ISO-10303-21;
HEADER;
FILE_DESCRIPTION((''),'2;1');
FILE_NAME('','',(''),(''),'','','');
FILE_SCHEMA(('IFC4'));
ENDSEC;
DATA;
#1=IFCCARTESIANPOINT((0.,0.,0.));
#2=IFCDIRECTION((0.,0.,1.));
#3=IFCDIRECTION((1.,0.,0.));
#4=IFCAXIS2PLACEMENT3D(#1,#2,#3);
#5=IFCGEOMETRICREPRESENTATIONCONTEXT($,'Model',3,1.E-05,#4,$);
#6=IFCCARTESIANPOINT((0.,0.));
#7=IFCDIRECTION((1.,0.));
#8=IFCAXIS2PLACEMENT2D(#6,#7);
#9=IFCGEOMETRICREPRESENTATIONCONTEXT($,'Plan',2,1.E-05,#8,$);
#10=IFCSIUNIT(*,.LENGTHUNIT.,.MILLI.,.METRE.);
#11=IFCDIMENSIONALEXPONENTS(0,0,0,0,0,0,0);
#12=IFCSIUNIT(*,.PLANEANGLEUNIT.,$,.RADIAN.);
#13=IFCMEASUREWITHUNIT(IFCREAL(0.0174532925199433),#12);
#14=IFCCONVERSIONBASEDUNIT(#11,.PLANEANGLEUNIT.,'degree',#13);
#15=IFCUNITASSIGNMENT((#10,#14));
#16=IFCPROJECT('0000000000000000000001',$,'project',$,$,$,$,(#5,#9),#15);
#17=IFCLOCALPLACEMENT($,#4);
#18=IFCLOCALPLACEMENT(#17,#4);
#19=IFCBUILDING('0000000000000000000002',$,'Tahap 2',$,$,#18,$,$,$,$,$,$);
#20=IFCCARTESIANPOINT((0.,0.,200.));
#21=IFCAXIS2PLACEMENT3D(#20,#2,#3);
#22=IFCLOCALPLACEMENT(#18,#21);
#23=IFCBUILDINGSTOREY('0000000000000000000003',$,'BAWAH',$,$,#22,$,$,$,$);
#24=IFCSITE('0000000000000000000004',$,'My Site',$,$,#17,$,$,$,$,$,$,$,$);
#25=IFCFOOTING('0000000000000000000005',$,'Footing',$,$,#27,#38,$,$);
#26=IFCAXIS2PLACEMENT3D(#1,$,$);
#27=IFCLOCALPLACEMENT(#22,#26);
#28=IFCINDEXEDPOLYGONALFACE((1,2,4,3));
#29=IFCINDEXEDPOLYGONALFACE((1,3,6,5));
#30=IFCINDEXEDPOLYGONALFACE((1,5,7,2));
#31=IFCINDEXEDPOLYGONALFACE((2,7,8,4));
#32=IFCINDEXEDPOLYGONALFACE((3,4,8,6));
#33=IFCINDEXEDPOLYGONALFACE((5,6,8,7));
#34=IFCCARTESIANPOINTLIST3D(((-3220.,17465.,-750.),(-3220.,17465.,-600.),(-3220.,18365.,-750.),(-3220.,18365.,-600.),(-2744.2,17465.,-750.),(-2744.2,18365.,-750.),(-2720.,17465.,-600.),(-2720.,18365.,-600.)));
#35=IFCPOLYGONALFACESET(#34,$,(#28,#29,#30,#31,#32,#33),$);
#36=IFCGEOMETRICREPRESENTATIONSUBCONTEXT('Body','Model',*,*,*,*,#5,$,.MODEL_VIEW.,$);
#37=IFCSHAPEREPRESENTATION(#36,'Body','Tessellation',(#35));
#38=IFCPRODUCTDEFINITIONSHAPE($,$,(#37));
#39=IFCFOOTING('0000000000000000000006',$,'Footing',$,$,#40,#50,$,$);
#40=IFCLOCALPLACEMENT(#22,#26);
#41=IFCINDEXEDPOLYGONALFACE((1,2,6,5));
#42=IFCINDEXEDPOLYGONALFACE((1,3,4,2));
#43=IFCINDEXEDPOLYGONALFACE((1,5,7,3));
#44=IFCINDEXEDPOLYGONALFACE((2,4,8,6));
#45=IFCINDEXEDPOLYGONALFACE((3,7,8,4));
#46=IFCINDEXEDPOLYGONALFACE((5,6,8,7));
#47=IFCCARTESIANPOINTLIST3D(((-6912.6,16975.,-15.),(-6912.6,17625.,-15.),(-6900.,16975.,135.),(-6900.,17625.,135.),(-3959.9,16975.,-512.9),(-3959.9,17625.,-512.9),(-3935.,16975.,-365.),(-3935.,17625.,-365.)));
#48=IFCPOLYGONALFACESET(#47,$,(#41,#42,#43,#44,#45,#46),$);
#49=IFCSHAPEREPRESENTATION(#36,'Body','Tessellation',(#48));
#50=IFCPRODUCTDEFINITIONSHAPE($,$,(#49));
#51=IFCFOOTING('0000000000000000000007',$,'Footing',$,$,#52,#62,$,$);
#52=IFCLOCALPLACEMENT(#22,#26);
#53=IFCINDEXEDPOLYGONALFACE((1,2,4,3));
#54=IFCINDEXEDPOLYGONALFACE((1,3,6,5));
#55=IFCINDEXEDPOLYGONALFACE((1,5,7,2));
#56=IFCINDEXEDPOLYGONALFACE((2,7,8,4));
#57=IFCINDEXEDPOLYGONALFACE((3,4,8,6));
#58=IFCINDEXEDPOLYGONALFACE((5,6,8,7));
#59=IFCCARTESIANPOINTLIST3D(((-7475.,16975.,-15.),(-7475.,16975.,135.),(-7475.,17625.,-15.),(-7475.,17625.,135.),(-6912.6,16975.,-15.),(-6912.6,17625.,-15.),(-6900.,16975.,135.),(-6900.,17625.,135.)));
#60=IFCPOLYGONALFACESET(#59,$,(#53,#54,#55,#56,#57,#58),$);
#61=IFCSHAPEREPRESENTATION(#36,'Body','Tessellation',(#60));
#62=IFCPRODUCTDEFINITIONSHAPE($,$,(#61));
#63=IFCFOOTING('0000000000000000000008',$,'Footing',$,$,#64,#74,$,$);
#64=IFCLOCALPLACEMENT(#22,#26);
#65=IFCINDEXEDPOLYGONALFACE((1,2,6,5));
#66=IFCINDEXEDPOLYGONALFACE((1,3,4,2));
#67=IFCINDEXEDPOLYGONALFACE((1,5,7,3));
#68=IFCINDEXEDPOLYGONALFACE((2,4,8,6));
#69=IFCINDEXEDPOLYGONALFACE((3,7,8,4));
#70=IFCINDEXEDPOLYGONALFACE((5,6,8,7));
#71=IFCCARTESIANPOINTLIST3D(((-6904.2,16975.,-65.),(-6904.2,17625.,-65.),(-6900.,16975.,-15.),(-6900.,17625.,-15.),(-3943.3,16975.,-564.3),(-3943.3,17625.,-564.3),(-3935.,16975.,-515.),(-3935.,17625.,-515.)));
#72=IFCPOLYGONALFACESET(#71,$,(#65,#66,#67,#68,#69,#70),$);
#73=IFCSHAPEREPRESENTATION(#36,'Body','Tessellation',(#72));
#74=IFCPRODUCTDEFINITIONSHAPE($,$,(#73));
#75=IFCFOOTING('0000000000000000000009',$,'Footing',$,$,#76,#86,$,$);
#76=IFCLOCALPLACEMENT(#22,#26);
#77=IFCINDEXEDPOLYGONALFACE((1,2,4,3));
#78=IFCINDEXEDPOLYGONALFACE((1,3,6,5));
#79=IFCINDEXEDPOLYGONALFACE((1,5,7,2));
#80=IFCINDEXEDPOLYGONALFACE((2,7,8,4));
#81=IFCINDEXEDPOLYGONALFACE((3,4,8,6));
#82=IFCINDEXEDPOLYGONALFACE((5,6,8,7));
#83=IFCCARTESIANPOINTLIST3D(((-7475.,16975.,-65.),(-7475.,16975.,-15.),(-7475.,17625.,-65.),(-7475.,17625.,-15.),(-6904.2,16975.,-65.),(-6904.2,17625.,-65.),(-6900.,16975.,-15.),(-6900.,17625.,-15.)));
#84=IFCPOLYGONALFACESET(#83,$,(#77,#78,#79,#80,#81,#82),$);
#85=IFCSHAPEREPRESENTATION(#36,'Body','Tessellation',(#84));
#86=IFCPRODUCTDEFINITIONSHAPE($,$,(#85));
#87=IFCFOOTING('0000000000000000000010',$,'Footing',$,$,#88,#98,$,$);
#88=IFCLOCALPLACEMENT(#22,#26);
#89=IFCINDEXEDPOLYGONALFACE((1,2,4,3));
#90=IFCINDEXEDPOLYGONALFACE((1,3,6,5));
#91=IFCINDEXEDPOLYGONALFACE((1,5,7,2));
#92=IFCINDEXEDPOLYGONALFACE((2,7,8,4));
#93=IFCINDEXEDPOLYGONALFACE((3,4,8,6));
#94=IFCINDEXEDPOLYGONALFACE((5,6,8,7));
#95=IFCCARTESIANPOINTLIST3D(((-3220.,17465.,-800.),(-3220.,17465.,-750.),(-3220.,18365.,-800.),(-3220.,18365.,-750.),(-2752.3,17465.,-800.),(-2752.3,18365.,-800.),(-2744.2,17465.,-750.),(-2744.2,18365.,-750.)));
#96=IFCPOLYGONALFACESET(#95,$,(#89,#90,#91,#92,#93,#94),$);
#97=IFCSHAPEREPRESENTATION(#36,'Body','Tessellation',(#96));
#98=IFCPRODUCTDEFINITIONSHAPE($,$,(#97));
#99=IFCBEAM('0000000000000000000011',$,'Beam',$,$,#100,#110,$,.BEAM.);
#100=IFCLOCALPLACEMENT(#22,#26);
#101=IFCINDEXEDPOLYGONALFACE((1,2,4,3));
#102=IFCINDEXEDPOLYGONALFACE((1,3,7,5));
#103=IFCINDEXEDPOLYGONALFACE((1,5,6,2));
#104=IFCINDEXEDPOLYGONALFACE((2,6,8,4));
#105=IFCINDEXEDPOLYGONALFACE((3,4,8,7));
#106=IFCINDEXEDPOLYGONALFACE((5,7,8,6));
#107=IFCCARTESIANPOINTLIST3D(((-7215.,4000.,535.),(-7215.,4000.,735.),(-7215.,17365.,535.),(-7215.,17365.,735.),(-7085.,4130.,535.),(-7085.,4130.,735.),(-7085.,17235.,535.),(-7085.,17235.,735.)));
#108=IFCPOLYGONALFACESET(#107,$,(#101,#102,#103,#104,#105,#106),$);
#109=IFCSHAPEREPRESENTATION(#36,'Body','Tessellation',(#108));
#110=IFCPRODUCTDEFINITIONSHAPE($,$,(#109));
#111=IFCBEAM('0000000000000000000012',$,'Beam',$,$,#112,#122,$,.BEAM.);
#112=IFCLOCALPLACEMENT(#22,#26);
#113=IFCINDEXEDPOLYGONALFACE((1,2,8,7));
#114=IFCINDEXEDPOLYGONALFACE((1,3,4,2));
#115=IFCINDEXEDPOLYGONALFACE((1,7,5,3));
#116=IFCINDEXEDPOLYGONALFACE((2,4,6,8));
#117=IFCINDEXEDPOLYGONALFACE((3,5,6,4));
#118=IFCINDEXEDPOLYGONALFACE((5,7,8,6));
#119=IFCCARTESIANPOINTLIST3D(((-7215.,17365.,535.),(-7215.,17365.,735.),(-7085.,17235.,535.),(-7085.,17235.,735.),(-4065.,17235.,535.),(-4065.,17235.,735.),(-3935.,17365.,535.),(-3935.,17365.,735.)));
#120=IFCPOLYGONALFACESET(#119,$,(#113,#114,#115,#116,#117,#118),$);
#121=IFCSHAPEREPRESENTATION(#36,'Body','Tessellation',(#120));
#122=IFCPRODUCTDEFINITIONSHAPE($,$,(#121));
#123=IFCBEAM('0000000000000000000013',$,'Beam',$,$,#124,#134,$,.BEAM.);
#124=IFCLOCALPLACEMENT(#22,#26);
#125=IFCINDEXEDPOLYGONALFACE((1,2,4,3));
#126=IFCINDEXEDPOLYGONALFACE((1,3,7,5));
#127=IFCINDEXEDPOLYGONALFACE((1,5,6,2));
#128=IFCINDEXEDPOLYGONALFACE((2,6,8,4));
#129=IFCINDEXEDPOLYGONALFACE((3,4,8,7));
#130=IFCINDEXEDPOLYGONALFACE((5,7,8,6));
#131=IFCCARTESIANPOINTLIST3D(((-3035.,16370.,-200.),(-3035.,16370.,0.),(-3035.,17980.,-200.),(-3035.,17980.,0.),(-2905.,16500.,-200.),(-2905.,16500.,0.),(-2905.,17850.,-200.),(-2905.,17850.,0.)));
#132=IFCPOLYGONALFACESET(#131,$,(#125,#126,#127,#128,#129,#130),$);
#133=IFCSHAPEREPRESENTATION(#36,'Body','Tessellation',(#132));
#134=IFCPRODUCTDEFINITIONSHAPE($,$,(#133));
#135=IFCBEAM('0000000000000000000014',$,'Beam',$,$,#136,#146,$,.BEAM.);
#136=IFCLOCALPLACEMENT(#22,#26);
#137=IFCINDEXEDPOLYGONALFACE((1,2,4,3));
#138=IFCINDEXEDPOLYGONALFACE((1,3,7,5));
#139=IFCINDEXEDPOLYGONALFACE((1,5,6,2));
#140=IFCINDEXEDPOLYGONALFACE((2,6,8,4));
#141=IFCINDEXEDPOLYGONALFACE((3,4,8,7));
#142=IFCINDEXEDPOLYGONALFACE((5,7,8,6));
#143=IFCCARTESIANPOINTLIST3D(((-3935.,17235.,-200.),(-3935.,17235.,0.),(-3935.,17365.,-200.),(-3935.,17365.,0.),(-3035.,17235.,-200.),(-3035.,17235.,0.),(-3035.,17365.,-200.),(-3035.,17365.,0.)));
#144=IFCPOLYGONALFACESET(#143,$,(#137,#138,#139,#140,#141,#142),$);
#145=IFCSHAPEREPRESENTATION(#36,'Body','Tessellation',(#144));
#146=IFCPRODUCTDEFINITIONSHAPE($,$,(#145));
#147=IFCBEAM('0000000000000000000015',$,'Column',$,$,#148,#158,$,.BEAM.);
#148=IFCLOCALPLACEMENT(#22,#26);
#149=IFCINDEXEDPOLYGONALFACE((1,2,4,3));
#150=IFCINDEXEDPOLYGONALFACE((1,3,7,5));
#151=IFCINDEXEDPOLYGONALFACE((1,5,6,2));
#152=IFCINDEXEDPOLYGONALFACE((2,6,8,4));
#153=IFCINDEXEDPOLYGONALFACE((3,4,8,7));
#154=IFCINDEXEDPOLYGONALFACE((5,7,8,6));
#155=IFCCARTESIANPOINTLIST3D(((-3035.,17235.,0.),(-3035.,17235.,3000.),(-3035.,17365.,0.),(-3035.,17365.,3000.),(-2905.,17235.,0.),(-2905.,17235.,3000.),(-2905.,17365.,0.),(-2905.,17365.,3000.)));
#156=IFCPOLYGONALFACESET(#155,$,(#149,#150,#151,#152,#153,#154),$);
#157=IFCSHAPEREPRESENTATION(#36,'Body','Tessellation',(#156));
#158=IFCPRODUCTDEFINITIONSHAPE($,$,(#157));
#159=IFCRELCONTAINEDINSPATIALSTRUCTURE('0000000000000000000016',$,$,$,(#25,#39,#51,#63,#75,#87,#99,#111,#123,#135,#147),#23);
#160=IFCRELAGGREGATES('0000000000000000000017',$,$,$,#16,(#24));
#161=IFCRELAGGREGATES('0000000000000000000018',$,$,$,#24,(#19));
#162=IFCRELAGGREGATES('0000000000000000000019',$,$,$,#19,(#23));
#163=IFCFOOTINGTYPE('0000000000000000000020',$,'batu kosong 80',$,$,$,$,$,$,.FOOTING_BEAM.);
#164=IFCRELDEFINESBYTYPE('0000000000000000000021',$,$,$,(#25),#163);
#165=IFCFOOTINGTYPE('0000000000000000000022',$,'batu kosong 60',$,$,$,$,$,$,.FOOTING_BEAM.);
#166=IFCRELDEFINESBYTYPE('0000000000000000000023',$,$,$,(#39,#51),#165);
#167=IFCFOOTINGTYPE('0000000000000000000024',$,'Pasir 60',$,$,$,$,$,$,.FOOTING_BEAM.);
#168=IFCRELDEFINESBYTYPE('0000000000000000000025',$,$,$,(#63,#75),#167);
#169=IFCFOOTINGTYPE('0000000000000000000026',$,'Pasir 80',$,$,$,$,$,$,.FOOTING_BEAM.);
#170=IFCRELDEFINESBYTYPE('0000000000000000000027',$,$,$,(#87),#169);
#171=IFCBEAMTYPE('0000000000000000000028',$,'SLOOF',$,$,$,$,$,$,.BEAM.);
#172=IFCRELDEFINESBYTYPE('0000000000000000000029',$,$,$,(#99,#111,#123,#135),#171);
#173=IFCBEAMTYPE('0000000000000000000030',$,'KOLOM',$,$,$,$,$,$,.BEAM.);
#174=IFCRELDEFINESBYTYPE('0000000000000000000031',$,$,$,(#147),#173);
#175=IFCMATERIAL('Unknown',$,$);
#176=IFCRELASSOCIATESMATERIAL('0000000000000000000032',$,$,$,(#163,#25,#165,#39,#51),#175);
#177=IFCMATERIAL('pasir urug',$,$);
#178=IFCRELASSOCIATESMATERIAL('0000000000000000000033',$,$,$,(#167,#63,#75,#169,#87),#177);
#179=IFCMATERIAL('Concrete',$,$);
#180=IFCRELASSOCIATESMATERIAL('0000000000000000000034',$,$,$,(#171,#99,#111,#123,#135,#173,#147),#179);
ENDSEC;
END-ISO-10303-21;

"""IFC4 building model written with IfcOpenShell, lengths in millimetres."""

from ifc_helpers import new_model, entity, si_unit, converted_unit, frame, origin_with_axes, origin_2d_with_axis, place, context, subcontext, project, spatial, indexed_curve, rectangle, outline, extrude, clip, halfspace, material, material_profile, profile_set, profile_usage, type_object, element, save


model = new_model("IFC4")

# Units and contexts
model_context = context("Model", 3, precision=1e-05, world=origin_with_axes())
plan_context = context("Plan", 2, precision=1e-05, world=origin_2d_with_axis())
body_context = subcontext(model_context, "Body", "Model", "MODEL_VIEW")
ifc_project = project(units=[si_unit("LENGTHUNIT", "METRE", prefix="MILLI"), converted_unit("PLANEANGLEUNIT", "degree", entity("IfcReal", 0.0174532925199433), si_unit("PLANEANGLEUNIT", "RADIAN"), dimensions=[0, 0, 0, 0, 0, 0, 0])], contexts=[model_context, plan_context])

# Site, building, storey
site_placement = place(None, origin_with_axes())
site = spatial("IfcSite", under=ifc_project, at=site_placement, Name="My Site")
building_placement = place(site_placement, origin_with_axes())
building = spatial("IfcBuilding", under=site, at=building_placement, Name="Tahap 2")
storey_placement = place(building_placement, frame((0.0, 0.0, 200.0), z_axis=(0.0, 0.0, 1.0), x_axis=(1.0, 0.0, 0.0)))
storey = spatial("IfcBuildingStorey", under=building, at=storey_placement, Name="BAWAH")

# Footings
ifc_material_1 = material(Name="Unknown")
ifc_material_profile_1 = material_profile(ifc_material_1, rectangle(XDim=900.0, YDim=150.0, kind="CURVE"))
ifc_profile_set_1 = profile_set([ifc_material_profile_1])
ifc_profile_usage_1 = profile_usage(ifc_profile_set_1, cardinal=8)
footing_type_1 = type_object("IfcFootingType", Name="batu kosong 80", PredefinedType="FOOTING_BEAM", material=ifc_profile_set_1)
footing_1_placement = place(storey_placement, frame((-1820.0, 17915.0, -600.0), z_axis=(-1.0, 0.0, 0.0), x_axis=(0.0, -1.0, 0.0)))
element("IfcFooting", 1, at=footing_1_placement, inside=storey, type_object=footing_type_1, material=ifc_profile_usage_1, Name="Footing", context=body_context, shape_type="Clipping", body=[
    clip(extrude(rectangle(XDim=900.0, YDim=150.0, kind="CURVE"), frame((0.0, -75.0, 0.0), z_axis=(0.0, 0.0, 1.0), x_axis=(1.0, 0.0, 0.0)), (0.0, 0.0, 1.0), 1400.0), halfspace(frame((17915.0, 0.0, 900.0), z_axis=(0.0, -0.159352, -0.987222), x_axis=(-1.0, 0.0, 0.0)), False)),
])
ifc_material_profile_2 = material_profile(ifc_material_1, rectangle(XDim=650.0, YDim=150.0, kind="CURVE"))
ifc_profile_set_2 = profile_set([ifc_material_profile_2])
ifc_profile_usage_2 = profile_usage(ifc_profile_set_2, cardinal=8)
footing_type_2 = type_object("IfcFootingType", Name="batu kosong 60", PredefinedType="FOOTING_BEAM", material=ifc_profile_set_2)
footing_2_placement = place(storey_placement, frame((-3935.0, 17300.0, -365.0), z_axis=(-0.986078, 0.0, 0.166286), x_axis=(0.0, -1.0, 0.0)))
element("IfcFooting", 2, at=footing_2_placement, inside=storey, type_object=footing_type_2, material=ifc_profile_usage_2, Name="Footing", context=body_context, shape_type="Clipping", body=[
    clip(extrude(rectangle(XDim=650.0, YDim=150.0, kind="CURVE"), frame((0.0, -75.0, 0.0), z_axis=(0.0, 0.0, 1.0), x_axis=(1.0, 0.0, 0.0)), (0.0, 0.0, 1.0), 3656.9), halfspace(frame((17300.0, 0.0, 3006.9), z_axis=(-0.000001, -0.08343, 0.996514), x_axis=(-1.0, 0.000008, 0.0)), False)),
])
ifc_profile_usage_3 = profile_usage(ifc_profile_set_2, cardinal=8)
footing_3_placement = place(storey_placement, frame((-6250.0, 17300.0, 135.0), z_axis=(-1.0, 0.0, 0.0), x_axis=(0.0, -1.0, 0.0)))
element("IfcFooting", 3, at=footing_3_placement, inside=storey, type_object=footing_type_2, material=ifc_profile_usage_3, Name="Footing", context=body_context, shape_type="Clipping", body=[
    clip(extrude(rectangle(XDim=650.0, YDim=150.0, kind="CURVE"), frame((0.0, -75.0, 0.0), z_axis=(0.0, 0.0, 1.0), x_axis=(1.0, 0.0, 0.0)), (0.0, 0.0, 1.0), 1225.0), halfspace(frame((17300.0, 0.0, 650.0), z_axis=(0.000001, -0.083437, -0.996513), x_axis=(-1.0, -0.000011, 0.0)), False)),
])
ifc_material_2 = material(Name="pasir urug")
ifc_material_profile_3 = material_profile(ifc_material_2, rectangle(XDim=650.0, YDim=50.0, kind="CURVE"))
ifc_profile_set_3 = profile_set([ifc_material_profile_3])
ifc_profile_usage_4 = profile_usage(ifc_profile_set_3, cardinal=8)
footing_type_3 = type_object("IfcFootingType", Name="Pasir 60", PredefinedType="FOOTING_BEAM", material=ifc_profile_set_3)
footing_4_placement = place(storey_placement, frame((-3935.0, 17300.0, -515.0), z_axis=(-0.986078, 0.0, 0.166286), x_axis=(0.0, -1.0, 0.0)))
element("IfcFooting", 4, at=footing_4_placement, inside=storey, type_object=footing_type_3, material=ifc_profile_usage_4, Name="Footing", context=body_context, shape_type="Clipping", body=[
    clip(extrude(rectangle(XDim=650.0, YDim=50.0, kind="CURVE"), frame((0.0, -25.0, 0.0), z_axis=(0.0, 0.0, 1.0), x_axis=(1.0, 0.0, 0.0)), (0.0, 0.0, 1.0), 3606.9), halfspace(frame((17300.0, 0.0, 3006.9), z_axis=(-0.000001, -0.083427, 0.996514), x_axis=(-1.0, 0.000008, 0.0)), False)),
])
ifc_profile_usage_5 = profile_usage(ifc_profile_set_3, cardinal=8)
footing_5_placement = place(storey_placement, frame((-6300.0, 17300.0, -15.0), z_axis=(-1.0, 0.0, 0.0), x_axis=(0.0, -1.0, 0.0)))
element("IfcFooting", 5, at=footing_5_placement, inside=storey, type_object=footing_type_3, material=ifc_profile_usage_5, Name="Footing", context=body_context, shape_type="Clipping", body=[
    clip(extrude(rectangle(XDim=650.0, YDim=50.0, kind="CURVE"), frame((0.0, -25.0, 0.0), z_axis=(0.0, 0.0, 1.0), x_axis=(1.0, 0.0, 0.0)), (0.0, 0.0, 1.0), 1175.0), halfspace(frame((17300.0, 0.0, 600.0), z_axis=(0.000001, -0.083431, -0.996514), x_axis=(-1.0, -0.000011, 0.0)), False)),
])
ifc_material_profile_4 = material_profile(ifc_material_2, rectangle(XDim=900.0, YDim=50.0, kind="CURVE"))
ifc_profile_set_4 = profile_set([ifc_material_profile_4])
ifc_profile_usage_6 = profile_usage(ifc_profile_set_4, cardinal=9)
footing_type_4 = type_object("IfcFootingType", Name="Pasir 80", PredefinedType="FOOTING_BEAM", material=ifc_profile_set_4)
footing_6_placement = place(storey_placement, frame((-1844.2, 18365.0, -750.0), z_axis=(-1.0, 0.0, 0.0), x_axis=(0.0, -1.0, 0.0)))
element("IfcFooting", 6, at=footing_6_placement, inside=storey, type_object=footing_type_4, material=ifc_profile_usage_6, Name="Footing", context=body_context, shape_type="Clipping", body=[
    clip(extrude(rectangle(XDim=900.0, YDim=50.0, kind="CURVE"), frame((450.0, -25.0, 0.0), z_axis=(0.0, 0.0, 1.0), x_axis=(1.0, 0.0, 0.0)), (0.0, 0.0, 1.0), 1375.8), halfspace(frame((18365.0, 0.0, 900.0), z_axis=(0.0, -0.159343, -0.987223), x_axis=(-1.0, 0.000001, 0.0)), False)),
])

# Beams
ifc_material_3 = material(Name="Concrete")
ifc_material_profile_5 = material_profile(ifc_material_3, outline(indexed_curve([(-65.0, 100.0), (65.0, 100.0), (65.0, -100.0), (-65.0, -100.0), (-65.0, 100.0)])))
ifc_profile_set_5 = profile_set([ifc_material_profile_5])
ifc_profile_usage_7 = profile_usage(ifc_profile_set_5, cardinal=2)
beam_type_1 = type_object("IfcBeamType", Name="SLOOF", PredefinedType="BEAM", material=ifc_profile_set_5)
beam_1_placement = place(storey_placement, frame((-7150.0, 17365.0, 535.0), z_axis=(0.0, -1.0, 0.0), x_axis=(1.0, 0.0, 0.0)))
element("IfcBeam", 7, at=beam_1_placement, inside=storey, type_object=beam_type_1, material=ifc_profile_usage_7, Name="Beam", PredefinedType="BEAM", context=body_context, shape_type="Clipping", body=[
    clip(clip(extrude(outline(indexed_curve([(-65.0, 100.0), (65.0, 100.0), (65.0, -100.0), (-65.0, -100.0), (-65.0, 100.0)])), frame((0.0, 100.0, 0.0), z_axis=(0.0, 0.0, 1.0), x_axis=(1.0, 0.0, 0.0)), (0.0, 0.0, 1.0), 13365.0), halfspace(frame((-65.0, -735.0, 13365.0), z_axis=(0.707107, 0.0, 0.707106), x_axis=(0.0, -1.0, 0.0)), False)), halfspace(frame((-65.0, -735.0, 0.0), z_axis=(0.707109, 0.0, -0.707104), x_axis=(0.0, -1.0, 0.0)), False)),
])
ifc_profile_usage_8 = profile_usage(ifc_profile_set_5, cardinal=2)
beam_2_placement = place(storey_placement, frame((-3935.0, 17300.0, 535.0), z_axis=(-1.0, 0.0, 0.0), x_axis=(0.0, -1.0, 0.0)))
element("IfcBeam", 8, at=beam_2_placement, inside=storey, type_object=beam_type_1, material=ifc_profile_usage_8, Name="Beam", PredefinedType="BEAM", context=body_context, shape_type="Clipping", body=[
    clip(clip(extrude(outline(indexed_curve([(-65.0, 100.0), (65.0, 100.0), (65.0, -100.0), (-65.0, -100.0), (-65.0, 100.0)])), frame((0.0, 100.0, 0.0), z_axis=(0.0, 0.0, 1.0), x_axis=(1.0, 0.0, 0.0)), (0.0, 0.0, 1.0), 3280.0), halfspace(frame((-65.0, -735.0, 3280.0), z_axis=(0.707104, 0.0, 0.70711), x_axis=(0.0, -1.0, 0.0)), False)), halfspace(frame((-65.0, -735.0, 0.0), z_axis=(0.707103, 0.0, -0.707111), x_axis=(0.0, -1.0, 0.0)), False)),
])
ifc_profile_usage_9 = profile_usage(ifc_profile_set_5, cardinal=2)
beam_3_placement = place(storey_placement, frame((-2970.0, 17980.0, -200.0), z_axis=(0.0, -1.0, -0.000003), x_axis=(1.0, 0.0, 0.0)))
element("IfcBeam", 9, at=beam_3_placement, inside=storey, type_object=beam_type_1, material=ifc_profile_usage_9, Name="Beam", PredefinedType="BEAM", context=body_context, shape_type="Clipping", body=[
    clip(clip(extrude(outline(indexed_curve([(-65.0, 100.0), (65.0, 100.0), (65.0, -100.0), (-65.0, -100.0), (-65.0, 100.0)])), frame((0.0, 100.0, 0.0), z_axis=(0.0, 0.0, 1.0), x_axis=(1.0, 0.0, 0.0)), (0.0, 0.0, 1.0), 1610.0), halfspace(frame((-65.0, 0.0, 1610.0), z_axis=(0.70711, 0.000002, 0.707104), x_axis=(0.000003, -1.0, 0.0)), False)), halfspace(frame((-65.0, 0.0, 0.0), z_axis=(0.707109, -0.000002, -0.707104), x_axis=(-0.000003, -1.0, 0.0)), False)),
])
ifc_profile_usage_10 = profile_usage(ifc_profile_set_5, cardinal=2)
beam_4_placement = place(storey_placement, frame((-3035.0, 17300.0, -200.0), z_axis=(-1.0, 0.0, 0.0), x_axis=(0.0, -1.0, 0.0)))
element("IfcBeam", 10, at=beam_4_placement, inside=storey, type_object=beam_type_1, material=ifc_profile_usage_10, Name="Beam", PredefinedType="BEAM", context=body_context, shape_type="SweptSolid", body=[
    extrude(outline(indexed_curve([(-65.0, 100.0), (65.0, 100.0), (65.0, -100.0), (-65.0, -100.0), (-65.0, 100.0)])), frame((0.0, 100.0, 0.0), z_axis=(0.0, 0.0, 1.0), x_axis=(1.0, 0.0, 0.0)), (0.0, 0.0, 1.0), 900.0),
])
ifc_material_profile_6 = material_profile(ifc_material_3, rectangle(XDim=130.0, YDim=130.0, kind="CURVE"))
ifc_profile_set_6 = profile_set([ifc_material_profile_6])
ifc_profile_usage_11 = profile_usage(ifc_profile_set_6, cardinal=2)
beam_type_2 = type_object("IfcBeamType", Name="KOLOM", PredefinedType="BEAM", material=ifc_profile_set_6)
beam_5_placement = place(storey_placement, frame((-2970.0, 17235.0, 0.0), z_axis=(0.0, 0.0, 1.0), x_axis=(1.0, 0.0, 0.0)))
element("IfcBeam", 11, at=beam_5_placement, inside=storey, type_object=beam_type_2, material=ifc_profile_usage_11, Name="Column", PredefinedType="BEAM", context=body_context, shape_type="SweptSolid", body=[
    extrude(rectangle(XDim=130.0, YDim=130.0, kind="CURVE"), frame((0.0, 65.0, 0.0), z_axis=(0.0, 0.0, 1.0), x_axis=(1.0, 0.0, 0.0)), (0.0, 0.0, 1.0), 3000.0),
])

save(model, "model.ifc")
